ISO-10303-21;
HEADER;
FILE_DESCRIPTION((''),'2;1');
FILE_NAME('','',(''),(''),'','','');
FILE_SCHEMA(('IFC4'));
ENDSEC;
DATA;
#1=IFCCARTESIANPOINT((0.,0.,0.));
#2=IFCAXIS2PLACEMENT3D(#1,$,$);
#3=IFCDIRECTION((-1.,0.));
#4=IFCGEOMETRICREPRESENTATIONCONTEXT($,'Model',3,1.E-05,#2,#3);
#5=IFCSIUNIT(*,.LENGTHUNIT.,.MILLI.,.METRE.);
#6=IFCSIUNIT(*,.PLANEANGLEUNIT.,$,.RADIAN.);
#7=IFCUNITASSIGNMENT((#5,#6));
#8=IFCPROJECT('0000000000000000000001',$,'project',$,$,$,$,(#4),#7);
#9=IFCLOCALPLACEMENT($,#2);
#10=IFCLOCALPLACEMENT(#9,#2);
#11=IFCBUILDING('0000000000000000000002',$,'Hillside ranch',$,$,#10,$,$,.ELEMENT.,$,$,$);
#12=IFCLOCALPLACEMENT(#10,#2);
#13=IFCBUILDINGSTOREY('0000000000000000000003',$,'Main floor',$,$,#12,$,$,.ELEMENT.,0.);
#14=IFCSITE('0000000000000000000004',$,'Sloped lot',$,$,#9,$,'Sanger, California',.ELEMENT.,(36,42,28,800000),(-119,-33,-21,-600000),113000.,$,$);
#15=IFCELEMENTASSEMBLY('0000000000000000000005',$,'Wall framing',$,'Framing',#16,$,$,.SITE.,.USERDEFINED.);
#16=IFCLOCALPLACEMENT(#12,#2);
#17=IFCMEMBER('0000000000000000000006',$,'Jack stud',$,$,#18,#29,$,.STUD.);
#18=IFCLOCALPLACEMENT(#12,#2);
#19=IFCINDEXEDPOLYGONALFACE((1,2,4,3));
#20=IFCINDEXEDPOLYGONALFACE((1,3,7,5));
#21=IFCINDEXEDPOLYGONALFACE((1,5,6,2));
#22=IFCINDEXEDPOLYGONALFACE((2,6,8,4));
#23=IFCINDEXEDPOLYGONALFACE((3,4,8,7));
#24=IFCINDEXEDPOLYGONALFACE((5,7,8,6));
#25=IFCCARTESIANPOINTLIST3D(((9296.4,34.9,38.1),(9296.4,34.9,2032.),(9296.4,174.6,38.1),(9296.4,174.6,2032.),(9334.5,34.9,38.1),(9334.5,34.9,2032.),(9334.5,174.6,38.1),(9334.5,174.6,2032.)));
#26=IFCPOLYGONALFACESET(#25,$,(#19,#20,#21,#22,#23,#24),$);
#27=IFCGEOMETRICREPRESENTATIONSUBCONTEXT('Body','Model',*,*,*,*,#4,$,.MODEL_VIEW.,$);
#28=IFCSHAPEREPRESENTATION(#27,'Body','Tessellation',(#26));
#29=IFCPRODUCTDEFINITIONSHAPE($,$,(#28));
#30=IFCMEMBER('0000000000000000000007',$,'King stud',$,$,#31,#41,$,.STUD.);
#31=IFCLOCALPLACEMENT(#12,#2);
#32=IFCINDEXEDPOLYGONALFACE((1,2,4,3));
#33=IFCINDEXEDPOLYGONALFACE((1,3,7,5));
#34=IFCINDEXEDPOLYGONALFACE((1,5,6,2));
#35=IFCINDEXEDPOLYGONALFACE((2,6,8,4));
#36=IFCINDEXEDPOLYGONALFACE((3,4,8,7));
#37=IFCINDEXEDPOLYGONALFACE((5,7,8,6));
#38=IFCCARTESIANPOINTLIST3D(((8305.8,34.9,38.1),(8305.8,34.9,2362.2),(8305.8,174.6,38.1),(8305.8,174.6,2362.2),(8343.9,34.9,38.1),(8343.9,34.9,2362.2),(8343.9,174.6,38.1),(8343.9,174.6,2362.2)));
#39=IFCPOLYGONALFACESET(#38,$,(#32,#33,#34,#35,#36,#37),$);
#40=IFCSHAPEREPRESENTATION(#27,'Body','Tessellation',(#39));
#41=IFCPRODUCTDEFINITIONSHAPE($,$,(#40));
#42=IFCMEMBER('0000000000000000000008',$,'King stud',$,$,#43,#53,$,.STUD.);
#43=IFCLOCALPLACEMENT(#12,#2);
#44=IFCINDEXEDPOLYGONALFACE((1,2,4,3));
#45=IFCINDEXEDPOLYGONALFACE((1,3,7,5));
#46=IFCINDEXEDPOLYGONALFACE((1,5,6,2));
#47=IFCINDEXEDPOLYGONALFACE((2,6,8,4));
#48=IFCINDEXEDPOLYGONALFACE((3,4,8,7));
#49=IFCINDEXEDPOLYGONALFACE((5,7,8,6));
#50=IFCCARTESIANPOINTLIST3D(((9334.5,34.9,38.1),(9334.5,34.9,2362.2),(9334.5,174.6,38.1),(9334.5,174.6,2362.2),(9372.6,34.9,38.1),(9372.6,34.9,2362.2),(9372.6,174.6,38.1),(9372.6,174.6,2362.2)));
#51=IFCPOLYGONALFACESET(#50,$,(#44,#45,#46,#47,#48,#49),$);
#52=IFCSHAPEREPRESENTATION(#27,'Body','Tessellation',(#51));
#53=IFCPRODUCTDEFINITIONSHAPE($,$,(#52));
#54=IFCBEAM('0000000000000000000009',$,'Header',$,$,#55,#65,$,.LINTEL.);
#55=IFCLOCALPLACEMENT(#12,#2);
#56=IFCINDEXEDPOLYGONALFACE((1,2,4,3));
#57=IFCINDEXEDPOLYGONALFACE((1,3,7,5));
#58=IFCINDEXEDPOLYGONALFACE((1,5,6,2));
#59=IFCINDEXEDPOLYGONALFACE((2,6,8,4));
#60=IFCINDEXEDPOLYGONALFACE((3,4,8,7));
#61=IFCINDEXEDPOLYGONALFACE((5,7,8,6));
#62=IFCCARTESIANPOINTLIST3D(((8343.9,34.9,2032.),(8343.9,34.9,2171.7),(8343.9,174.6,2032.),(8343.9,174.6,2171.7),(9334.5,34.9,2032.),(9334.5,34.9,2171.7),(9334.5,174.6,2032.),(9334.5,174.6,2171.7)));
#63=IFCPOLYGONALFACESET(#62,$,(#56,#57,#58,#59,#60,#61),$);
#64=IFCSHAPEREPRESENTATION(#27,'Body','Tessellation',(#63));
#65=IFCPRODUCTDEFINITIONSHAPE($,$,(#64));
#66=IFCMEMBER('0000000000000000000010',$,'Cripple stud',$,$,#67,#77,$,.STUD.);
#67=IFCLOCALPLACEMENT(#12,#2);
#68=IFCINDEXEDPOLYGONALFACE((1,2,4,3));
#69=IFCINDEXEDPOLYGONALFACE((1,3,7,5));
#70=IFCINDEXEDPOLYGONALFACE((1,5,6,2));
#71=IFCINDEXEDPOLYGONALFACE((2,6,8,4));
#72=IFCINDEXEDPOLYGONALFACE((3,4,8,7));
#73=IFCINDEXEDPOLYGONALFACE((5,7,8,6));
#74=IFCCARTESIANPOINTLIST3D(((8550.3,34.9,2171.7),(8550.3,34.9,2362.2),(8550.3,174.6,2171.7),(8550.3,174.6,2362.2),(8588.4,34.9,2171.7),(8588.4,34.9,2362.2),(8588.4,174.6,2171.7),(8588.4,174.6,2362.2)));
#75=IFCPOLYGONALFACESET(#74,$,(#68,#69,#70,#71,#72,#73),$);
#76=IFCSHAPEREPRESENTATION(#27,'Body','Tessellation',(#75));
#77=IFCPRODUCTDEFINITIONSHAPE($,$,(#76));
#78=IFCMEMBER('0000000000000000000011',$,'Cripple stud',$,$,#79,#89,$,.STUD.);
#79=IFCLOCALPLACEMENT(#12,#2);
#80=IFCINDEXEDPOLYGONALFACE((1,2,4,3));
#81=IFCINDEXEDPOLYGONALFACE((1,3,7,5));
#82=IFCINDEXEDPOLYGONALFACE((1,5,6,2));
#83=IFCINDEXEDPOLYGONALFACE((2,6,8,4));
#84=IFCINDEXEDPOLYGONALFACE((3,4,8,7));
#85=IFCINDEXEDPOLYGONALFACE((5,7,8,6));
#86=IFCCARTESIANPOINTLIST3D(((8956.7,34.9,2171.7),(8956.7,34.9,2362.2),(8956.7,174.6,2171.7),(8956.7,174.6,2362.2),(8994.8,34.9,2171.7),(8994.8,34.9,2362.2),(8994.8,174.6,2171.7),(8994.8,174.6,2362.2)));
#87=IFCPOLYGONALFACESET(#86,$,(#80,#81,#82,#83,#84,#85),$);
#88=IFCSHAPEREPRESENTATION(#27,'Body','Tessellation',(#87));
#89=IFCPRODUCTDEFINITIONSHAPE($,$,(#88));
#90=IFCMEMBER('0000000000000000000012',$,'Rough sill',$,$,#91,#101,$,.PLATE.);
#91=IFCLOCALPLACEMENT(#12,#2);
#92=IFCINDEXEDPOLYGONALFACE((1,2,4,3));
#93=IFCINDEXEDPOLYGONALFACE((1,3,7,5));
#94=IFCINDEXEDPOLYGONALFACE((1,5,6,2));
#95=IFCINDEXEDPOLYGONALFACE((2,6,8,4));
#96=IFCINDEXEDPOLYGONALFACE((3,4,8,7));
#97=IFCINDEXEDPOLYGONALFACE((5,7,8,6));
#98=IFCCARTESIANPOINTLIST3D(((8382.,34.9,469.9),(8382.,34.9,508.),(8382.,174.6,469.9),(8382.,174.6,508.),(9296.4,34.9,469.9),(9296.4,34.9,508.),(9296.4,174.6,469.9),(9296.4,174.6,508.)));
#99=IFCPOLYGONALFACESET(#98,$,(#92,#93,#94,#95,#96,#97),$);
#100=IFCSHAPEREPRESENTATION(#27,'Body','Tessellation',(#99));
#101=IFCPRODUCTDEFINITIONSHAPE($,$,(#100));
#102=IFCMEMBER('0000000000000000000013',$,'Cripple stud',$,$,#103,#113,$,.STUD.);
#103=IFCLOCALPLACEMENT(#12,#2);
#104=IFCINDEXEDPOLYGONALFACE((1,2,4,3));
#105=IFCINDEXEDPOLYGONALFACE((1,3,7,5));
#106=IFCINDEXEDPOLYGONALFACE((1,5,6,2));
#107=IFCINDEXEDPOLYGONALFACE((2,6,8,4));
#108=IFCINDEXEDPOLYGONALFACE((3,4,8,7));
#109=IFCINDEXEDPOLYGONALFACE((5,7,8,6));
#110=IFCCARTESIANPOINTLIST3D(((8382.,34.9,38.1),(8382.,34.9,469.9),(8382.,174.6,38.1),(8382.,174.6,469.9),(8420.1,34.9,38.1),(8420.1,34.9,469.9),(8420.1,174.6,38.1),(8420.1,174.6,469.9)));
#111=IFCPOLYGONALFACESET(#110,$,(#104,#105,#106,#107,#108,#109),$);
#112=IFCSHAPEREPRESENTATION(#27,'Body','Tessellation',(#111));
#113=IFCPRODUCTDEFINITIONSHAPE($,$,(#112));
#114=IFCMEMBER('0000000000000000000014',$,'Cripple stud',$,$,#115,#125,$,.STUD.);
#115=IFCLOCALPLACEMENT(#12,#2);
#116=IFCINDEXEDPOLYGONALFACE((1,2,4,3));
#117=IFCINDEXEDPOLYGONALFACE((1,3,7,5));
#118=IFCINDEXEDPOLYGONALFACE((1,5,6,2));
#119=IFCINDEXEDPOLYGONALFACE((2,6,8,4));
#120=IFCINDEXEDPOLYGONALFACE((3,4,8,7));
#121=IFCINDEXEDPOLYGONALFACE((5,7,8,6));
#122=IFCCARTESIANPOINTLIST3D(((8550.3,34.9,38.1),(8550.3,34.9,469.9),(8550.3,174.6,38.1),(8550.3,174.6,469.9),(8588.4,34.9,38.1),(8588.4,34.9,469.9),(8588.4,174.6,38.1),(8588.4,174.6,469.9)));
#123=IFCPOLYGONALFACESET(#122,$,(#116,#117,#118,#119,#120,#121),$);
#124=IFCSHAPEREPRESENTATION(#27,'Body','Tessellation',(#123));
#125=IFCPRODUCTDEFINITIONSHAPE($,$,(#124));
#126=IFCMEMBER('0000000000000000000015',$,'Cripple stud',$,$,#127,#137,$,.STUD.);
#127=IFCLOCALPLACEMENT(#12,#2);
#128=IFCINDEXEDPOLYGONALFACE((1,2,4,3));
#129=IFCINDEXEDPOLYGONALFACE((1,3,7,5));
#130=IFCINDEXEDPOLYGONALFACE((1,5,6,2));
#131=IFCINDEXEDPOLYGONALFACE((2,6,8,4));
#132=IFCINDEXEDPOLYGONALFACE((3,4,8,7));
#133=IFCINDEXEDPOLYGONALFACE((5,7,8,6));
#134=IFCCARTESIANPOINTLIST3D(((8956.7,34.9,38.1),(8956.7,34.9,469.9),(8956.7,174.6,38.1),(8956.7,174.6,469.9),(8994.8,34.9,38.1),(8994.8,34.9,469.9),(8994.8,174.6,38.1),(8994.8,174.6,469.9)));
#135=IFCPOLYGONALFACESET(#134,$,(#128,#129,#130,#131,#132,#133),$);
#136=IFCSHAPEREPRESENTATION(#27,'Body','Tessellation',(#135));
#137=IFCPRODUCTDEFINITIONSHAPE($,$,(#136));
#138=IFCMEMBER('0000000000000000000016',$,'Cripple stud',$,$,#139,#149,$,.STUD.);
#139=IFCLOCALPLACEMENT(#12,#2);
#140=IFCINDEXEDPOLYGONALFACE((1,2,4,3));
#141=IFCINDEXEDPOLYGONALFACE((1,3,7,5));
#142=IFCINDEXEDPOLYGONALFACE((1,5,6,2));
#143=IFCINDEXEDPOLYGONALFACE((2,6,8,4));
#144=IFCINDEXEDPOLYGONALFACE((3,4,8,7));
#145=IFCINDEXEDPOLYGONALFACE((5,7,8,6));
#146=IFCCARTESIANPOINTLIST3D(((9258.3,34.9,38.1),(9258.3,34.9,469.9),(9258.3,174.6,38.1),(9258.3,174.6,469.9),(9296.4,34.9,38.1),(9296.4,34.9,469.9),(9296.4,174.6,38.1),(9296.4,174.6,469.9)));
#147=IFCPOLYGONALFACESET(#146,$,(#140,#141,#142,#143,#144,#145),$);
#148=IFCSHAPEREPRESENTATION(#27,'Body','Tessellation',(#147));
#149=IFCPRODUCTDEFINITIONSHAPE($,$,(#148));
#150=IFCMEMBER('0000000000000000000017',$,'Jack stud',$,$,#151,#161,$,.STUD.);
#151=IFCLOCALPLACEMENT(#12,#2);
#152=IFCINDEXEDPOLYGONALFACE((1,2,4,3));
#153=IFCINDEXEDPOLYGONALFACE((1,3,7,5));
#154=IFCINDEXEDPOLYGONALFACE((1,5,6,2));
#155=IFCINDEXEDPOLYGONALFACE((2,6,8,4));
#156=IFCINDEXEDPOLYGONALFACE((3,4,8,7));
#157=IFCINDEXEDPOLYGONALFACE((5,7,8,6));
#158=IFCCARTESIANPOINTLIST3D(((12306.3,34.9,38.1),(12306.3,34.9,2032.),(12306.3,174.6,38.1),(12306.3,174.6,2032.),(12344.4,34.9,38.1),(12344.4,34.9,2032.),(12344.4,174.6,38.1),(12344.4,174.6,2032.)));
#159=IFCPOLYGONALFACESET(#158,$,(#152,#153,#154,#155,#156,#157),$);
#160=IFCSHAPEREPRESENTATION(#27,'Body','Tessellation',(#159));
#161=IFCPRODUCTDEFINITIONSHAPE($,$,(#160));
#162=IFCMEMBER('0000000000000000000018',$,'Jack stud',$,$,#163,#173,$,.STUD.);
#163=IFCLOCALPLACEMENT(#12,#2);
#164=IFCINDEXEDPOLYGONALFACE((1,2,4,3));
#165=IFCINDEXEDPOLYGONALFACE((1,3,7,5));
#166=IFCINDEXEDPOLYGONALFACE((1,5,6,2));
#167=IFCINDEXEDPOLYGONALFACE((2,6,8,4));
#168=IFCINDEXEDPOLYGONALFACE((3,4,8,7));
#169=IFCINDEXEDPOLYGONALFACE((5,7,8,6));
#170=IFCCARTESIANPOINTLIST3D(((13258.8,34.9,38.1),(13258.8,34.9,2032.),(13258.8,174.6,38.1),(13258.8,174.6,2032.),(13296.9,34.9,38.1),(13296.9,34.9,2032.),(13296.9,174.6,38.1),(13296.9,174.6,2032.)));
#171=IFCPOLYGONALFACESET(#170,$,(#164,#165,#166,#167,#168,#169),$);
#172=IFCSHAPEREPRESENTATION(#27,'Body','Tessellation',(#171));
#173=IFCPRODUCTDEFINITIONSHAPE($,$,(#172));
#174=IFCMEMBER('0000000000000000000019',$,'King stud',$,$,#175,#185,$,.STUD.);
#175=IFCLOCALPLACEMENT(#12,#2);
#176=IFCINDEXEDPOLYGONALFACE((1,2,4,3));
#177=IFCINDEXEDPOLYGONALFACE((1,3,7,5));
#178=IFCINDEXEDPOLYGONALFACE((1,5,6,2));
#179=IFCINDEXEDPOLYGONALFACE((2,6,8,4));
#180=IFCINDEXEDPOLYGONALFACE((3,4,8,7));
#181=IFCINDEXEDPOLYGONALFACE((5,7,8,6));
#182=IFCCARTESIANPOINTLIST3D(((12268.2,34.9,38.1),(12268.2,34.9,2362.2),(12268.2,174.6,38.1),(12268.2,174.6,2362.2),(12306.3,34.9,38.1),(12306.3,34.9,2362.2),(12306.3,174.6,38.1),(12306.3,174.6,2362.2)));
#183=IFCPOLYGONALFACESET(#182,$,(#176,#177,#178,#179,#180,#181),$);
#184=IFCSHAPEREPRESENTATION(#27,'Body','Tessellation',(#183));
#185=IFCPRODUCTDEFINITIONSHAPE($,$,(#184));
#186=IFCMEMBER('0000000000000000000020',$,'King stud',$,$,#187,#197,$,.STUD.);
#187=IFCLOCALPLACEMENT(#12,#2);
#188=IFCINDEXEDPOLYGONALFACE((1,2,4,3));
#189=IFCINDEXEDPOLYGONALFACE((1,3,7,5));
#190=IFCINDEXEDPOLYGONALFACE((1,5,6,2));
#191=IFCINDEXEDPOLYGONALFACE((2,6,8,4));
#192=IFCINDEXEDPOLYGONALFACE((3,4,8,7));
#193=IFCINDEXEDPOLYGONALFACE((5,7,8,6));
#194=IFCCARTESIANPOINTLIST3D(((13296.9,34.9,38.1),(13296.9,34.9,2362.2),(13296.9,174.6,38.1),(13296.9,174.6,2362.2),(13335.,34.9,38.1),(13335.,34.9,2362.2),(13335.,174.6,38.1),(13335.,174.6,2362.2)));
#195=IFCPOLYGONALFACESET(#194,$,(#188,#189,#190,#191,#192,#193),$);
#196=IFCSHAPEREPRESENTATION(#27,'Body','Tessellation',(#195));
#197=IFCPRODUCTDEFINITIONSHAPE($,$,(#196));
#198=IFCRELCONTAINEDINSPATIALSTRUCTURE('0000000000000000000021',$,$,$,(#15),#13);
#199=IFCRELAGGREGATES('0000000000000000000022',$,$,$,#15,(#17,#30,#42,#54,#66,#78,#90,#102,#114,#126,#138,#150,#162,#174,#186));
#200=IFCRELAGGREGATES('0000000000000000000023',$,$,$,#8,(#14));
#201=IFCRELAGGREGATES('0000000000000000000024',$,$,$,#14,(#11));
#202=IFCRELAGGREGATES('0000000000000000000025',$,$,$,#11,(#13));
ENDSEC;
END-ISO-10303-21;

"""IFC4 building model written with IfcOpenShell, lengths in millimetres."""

from ifc_helpers import new_model, si_unit, direction, frame, origin, origin_with_axes, place, context, subcontext, project, spatial, polyline, outline, extrude, element, aggregate, save


model = new_model("IFC4")

# Units and contexts
model_context = context("Model", 3, precision=1e-05, world=origin(), true_north=direction((-1.0, 0.0)))
body_context = subcontext(model_context, "Body", "Model", "MODEL_VIEW")
ifc_project = project(units=[si_unit("LENGTHUNIT", "METRE", prefix="MILLI"), si_unit("PLANEANGLEUNIT", "RADIAN")], contexts=[model_context])

# Site, building, storey
site_placement = place(None, origin())
site = spatial("IfcSite", under=ifc_project, at=site_placement, Name="Sloped lot", LongName="Sanger, California", CompositionType="ELEMENT", RefLatitude=(36, 42, 28, 800000), RefLongitude=(-119, -33, -21, -600000), RefElevation=113000.0)
building_placement = place(site_placement, origin())
building = spatial("IfcBuilding", under=site, at=building_placement, Name="Hillside ranch", CompositionType="ELEMENT")
storey_placement = place(building_placement, origin())
storey = spatial("IfcBuildingStorey", under=building, at=storey_placement, Name="Main floor", CompositionType="ELEMENT", Elevation=0.0)

# Element assembly, members, beam
assembly_placement = place(storey_placement, origin_with_axes())
assembly = element("IfcElementAssembly", 1, at=assembly_placement, inside=storey, Name="Wall framing", ObjectType="Framing", AssemblyPlace="SITE", PredefinedType="USERDEFINED")
member_1_placement = place(storey_placement, origin_with_axes())
member_1 = element("IfcMember", 2, at=member_1_placement, Name="Jack stud", PredefinedType="STUD", context=body_context, shape_type="SweptSolid", body=[
    extrude(outline(polyline([(0.0, 0.0), (38.1, 0.0), (38.1, 139.7), (0.0, 139.7), (0.0, 0.0)])), frame((9296.4, 34.9, 38.1), z_axis=(0.0, 0.0, 1.0), x_axis=(1.0, 0.0, 0.0)), (0.0, 0.0, 1.0), 1993.9),
])
member_2_placement = place(storey_placement, origin_with_axes())
member_2 = element("IfcMember", 3, at=member_2_placement, Name="King stud", PredefinedType="STUD", context=body_context, shape_type="SweptSolid", body=[
    extrude(outline(polyline([(0.0, 0.0), (38.1, 0.0), (38.1, 139.7), (0.0, 139.7), (0.0, 0.0)])), frame((8305.8, 34.9, 38.1), z_axis=(0.0, 0.0, 1.0), x_axis=(1.0, 0.0, 0.0)), (0.0, 0.0, 1.0), 2324.1),
])
member_3_placement = place(storey_placement, origin_with_axes())
member_3 = element("IfcMember", 4, at=member_3_placement, Name="King stud", PredefinedType="STUD", context=body_context, shape_type="SweptSolid", body=[
    extrude(outline(polyline([(0.0, 0.0), (38.1, 0.0), (38.1, 139.7), (0.0, 139.7), (0.0, 0.0)])), frame((9334.5, 34.9, 38.1), z_axis=(0.0, 0.0, 1.0), x_axis=(1.0, 0.0, 0.0)), (0.0, 0.0, 1.0), 2324.1),
])
beam_1_placement = place(storey_placement, origin_with_axes())
beam_1 = element("IfcBeam", 5, at=beam_1_placement, Name="Header", PredefinedType="LINTEL", context=body_context, shape_type="SweptSolid", body=[
    extrude(outline(polyline([(0.0, 0.0), (990.6, 0.0), (990.6, 139.7), (0.0, 139.7), (0.0, 0.0)])), frame((8343.9, 34.9, 2032.0), z_axis=(0.0, 0.0, 1.0), x_axis=(1.0, 0.0, 0.0)), (0.0, 0.0, 1.0), 139.7),
])
member_4_placement = place(storey_placement, origin_with_axes())
member_4 = element("IfcMember", 6, at=member_4_placement, Name="Cripple stud", PredefinedType="STUD", context=body_context, shape_type="SweptSolid", body=[
    extrude(outline(polyline([(0.0, 0.0), (38.1, 0.0), (38.1, 139.7), (0.0, 139.7), (0.0, 0.0)])), frame((8550.3, 34.9, 2171.7), z_axis=(0.0, 0.0, 1.0), x_axis=(1.0, 0.0, 0.0)), (0.0, 0.0, 1.0), 190.5),
])
member_5_placement = place(storey_placement, origin_with_axes())
member_5 = element("IfcMember", 7, at=member_5_placement, Name="Cripple stud", PredefinedType="STUD", context=body_context, shape_type="SweptSolid", body=[
    extrude(outline(polyline([(0.0, 0.0), (38.1, 0.0), (38.1, 139.7), (0.0, 139.7), (0.0, 0.0)])), frame((8956.7, 34.9, 2171.7), z_axis=(0.0, 0.0, 1.0), x_axis=(1.0, 0.0, 0.0)), (0.0, 0.0, 1.0), 190.5),
])
member_6_placement = place(storey_placement, origin_with_axes())
member_6 = element("IfcMember", 8, at=member_6_placement, Name="Rough sill", PredefinedType="PLATE", context=body_context, shape_type="SweptSolid", body=[
    extrude(outline(polyline([(0.0, 0.0), (914.4, 0.0), (914.4, 139.7), (0.0, 139.7), (0.0, 0.0)])), frame((8382.0, 34.9, 469.9), z_axis=(0.0, 0.0, 1.0), x_axis=(1.0, 0.0, 0.0)), (0.0, 0.0, 1.0), 38.1),
])
member_7_placement = place(storey_placement, origin_with_axes())
member_7 = element("IfcMember", 9, at=member_7_placement, Name="Cripple stud", PredefinedType="STUD", context=body_context, shape_type="SweptSolid", body=[
    extrude(outline(polyline([(0.0, 0.0), (38.1, 0.0), (38.1, 139.7), (0.0, 139.7), (0.0, 0.0)])), frame((8382.0, 34.9, 38.1), z_axis=(0.0, 0.0, 1.0), x_axis=(1.0, 0.0, 0.0)), (0.0, 0.0, 1.0), 431.8),
])
member_8_placement = place(storey_placement, origin_with_axes())
member_8 = element("IfcMember", 10, at=member_8_placement, Name="Cripple stud", PredefinedType="STUD", context=body_context, shape_type="SweptSolid", body=[
    extrude(outline(polyline([(0.0, 0.0), (38.1, 0.0), (38.1, 139.7), (0.0, 139.7), (0.0, 0.0)])), frame((8550.3, 34.9, 38.1), z_axis=(0.0, 0.0, 1.0), x_axis=(1.0, 0.0, 0.0)), (0.0, 0.0, 1.0), 431.8),
])
member_9_placement = place(storey_placement, origin_with_axes())
member_9 = element("IfcMember", 11, at=member_9_placement, Name="Cripple stud", PredefinedType="STUD", context=body_context, shape_type="SweptSolid", body=[
    extrude(outline(polyline([(0.0, 0.0), (38.1, 0.0), (38.1, 139.7), (0.0, 139.7), (0.0, 0.0)])), frame((8956.7, 34.9, 38.1), z_axis=(0.0, 0.0, 1.0), x_axis=(1.0, 0.0, 0.0)), (0.0, 0.0, 1.0), 431.8),
])
member_10_placement = place(storey_placement, origin_with_axes())
member_10 = element("IfcMember", 12, at=member_10_placement, Name="Cripple stud", PredefinedType="STUD", context=body_context, shape_type="SweptSolid", body=[
    extrude(outline(polyline([(0.0, 0.0), (38.1, 0.0), (38.1, 139.7), (0.0, 139.7), (0.0, 0.0)])), frame((9258.3, 34.9, 38.1), z_axis=(0.0, 0.0, 1.0), x_axis=(1.0, 0.0, 0.0)), (0.0, 0.0, 1.0), 431.8),
])
member_11_placement = place(storey_placement, origin_with_axes())
member_11 = element("IfcMember", 13, at=member_11_placement, Name="Jack stud", PredefinedType="STUD", context=body_context, shape_type="SweptSolid", body=[
    extrude(outline(polyline([(0.0, 0.0), (38.1, 0.0), (38.1, 139.7), (0.0, 139.7), (0.0, 0.0)])), frame((12306.3, 34.9, 38.1), z_axis=(0.0, 0.0, 1.0), x_axis=(1.0, 0.0, 0.0)), (0.0, 0.0, 1.0), 1993.9),
])
member_12_placement = place(storey_placement, origin_with_axes())
member_12 = element("IfcMember", 14, at=member_12_placement, Name="Jack stud", PredefinedType="STUD", context=body_context, shape_type="SweptSolid", body=[
    extrude(outline(polyline([(0.0, 0.0), (38.1, 0.0), (38.1, 139.7), (0.0, 139.7), (0.0, 0.0)])), frame((13258.8, 34.9, 38.1), z_axis=(0.0, 0.0, 1.0), x_axis=(1.0, 0.0, 0.0)), (0.0, 0.0, 1.0), 1993.9),
])
member_13_placement = place(storey_placement, origin_with_axes())
member_13 = element("IfcMember", 15, at=member_13_placement, Name="King stud", PredefinedType="STUD", context=body_context, shape_type="SweptSolid", body=[
    extrude(outline(polyline([(0.0, 0.0), (38.1, 0.0), (38.1, 139.7), (0.0, 139.7), (0.0, 0.0)])), frame((12268.2, 34.9, 38.1), z_axis=(0.0, 0.0, 1.0), x_axis=(1.0, 0.0, 0.0)), (0.0, 0.0, 1.0), 2324.1),
])
member_14_placement = place(storey_placement, origin_with_axes())
member_14 = element("IfcMember", 16, at=member_14_placement, Name="King stud", PredefinedType="STUD", context=body_context, shape_type="SweptSolid", body=[
    extrude(outline(polyline([(0.0, 0.0), (38.1, 0.0), (38.1, 139.7), (0.0, 139.7), (0.0, 0.0)])), frame((13296.9, 34.9, 38.1), z_axis=(0.0, 0.0, 1.0), x_axis=(1.0, 0.0, 0.0)), (0.0, 0.0, 1.0), 2324.1),
])
aggregate(assembly, [member_1, member_2, member_3, beam_1, member_4, member_5, member_6, member_7, member_8, member_9, member_10, member_11, member_12, member_13, member_14])

save(model, "model.ifc")
